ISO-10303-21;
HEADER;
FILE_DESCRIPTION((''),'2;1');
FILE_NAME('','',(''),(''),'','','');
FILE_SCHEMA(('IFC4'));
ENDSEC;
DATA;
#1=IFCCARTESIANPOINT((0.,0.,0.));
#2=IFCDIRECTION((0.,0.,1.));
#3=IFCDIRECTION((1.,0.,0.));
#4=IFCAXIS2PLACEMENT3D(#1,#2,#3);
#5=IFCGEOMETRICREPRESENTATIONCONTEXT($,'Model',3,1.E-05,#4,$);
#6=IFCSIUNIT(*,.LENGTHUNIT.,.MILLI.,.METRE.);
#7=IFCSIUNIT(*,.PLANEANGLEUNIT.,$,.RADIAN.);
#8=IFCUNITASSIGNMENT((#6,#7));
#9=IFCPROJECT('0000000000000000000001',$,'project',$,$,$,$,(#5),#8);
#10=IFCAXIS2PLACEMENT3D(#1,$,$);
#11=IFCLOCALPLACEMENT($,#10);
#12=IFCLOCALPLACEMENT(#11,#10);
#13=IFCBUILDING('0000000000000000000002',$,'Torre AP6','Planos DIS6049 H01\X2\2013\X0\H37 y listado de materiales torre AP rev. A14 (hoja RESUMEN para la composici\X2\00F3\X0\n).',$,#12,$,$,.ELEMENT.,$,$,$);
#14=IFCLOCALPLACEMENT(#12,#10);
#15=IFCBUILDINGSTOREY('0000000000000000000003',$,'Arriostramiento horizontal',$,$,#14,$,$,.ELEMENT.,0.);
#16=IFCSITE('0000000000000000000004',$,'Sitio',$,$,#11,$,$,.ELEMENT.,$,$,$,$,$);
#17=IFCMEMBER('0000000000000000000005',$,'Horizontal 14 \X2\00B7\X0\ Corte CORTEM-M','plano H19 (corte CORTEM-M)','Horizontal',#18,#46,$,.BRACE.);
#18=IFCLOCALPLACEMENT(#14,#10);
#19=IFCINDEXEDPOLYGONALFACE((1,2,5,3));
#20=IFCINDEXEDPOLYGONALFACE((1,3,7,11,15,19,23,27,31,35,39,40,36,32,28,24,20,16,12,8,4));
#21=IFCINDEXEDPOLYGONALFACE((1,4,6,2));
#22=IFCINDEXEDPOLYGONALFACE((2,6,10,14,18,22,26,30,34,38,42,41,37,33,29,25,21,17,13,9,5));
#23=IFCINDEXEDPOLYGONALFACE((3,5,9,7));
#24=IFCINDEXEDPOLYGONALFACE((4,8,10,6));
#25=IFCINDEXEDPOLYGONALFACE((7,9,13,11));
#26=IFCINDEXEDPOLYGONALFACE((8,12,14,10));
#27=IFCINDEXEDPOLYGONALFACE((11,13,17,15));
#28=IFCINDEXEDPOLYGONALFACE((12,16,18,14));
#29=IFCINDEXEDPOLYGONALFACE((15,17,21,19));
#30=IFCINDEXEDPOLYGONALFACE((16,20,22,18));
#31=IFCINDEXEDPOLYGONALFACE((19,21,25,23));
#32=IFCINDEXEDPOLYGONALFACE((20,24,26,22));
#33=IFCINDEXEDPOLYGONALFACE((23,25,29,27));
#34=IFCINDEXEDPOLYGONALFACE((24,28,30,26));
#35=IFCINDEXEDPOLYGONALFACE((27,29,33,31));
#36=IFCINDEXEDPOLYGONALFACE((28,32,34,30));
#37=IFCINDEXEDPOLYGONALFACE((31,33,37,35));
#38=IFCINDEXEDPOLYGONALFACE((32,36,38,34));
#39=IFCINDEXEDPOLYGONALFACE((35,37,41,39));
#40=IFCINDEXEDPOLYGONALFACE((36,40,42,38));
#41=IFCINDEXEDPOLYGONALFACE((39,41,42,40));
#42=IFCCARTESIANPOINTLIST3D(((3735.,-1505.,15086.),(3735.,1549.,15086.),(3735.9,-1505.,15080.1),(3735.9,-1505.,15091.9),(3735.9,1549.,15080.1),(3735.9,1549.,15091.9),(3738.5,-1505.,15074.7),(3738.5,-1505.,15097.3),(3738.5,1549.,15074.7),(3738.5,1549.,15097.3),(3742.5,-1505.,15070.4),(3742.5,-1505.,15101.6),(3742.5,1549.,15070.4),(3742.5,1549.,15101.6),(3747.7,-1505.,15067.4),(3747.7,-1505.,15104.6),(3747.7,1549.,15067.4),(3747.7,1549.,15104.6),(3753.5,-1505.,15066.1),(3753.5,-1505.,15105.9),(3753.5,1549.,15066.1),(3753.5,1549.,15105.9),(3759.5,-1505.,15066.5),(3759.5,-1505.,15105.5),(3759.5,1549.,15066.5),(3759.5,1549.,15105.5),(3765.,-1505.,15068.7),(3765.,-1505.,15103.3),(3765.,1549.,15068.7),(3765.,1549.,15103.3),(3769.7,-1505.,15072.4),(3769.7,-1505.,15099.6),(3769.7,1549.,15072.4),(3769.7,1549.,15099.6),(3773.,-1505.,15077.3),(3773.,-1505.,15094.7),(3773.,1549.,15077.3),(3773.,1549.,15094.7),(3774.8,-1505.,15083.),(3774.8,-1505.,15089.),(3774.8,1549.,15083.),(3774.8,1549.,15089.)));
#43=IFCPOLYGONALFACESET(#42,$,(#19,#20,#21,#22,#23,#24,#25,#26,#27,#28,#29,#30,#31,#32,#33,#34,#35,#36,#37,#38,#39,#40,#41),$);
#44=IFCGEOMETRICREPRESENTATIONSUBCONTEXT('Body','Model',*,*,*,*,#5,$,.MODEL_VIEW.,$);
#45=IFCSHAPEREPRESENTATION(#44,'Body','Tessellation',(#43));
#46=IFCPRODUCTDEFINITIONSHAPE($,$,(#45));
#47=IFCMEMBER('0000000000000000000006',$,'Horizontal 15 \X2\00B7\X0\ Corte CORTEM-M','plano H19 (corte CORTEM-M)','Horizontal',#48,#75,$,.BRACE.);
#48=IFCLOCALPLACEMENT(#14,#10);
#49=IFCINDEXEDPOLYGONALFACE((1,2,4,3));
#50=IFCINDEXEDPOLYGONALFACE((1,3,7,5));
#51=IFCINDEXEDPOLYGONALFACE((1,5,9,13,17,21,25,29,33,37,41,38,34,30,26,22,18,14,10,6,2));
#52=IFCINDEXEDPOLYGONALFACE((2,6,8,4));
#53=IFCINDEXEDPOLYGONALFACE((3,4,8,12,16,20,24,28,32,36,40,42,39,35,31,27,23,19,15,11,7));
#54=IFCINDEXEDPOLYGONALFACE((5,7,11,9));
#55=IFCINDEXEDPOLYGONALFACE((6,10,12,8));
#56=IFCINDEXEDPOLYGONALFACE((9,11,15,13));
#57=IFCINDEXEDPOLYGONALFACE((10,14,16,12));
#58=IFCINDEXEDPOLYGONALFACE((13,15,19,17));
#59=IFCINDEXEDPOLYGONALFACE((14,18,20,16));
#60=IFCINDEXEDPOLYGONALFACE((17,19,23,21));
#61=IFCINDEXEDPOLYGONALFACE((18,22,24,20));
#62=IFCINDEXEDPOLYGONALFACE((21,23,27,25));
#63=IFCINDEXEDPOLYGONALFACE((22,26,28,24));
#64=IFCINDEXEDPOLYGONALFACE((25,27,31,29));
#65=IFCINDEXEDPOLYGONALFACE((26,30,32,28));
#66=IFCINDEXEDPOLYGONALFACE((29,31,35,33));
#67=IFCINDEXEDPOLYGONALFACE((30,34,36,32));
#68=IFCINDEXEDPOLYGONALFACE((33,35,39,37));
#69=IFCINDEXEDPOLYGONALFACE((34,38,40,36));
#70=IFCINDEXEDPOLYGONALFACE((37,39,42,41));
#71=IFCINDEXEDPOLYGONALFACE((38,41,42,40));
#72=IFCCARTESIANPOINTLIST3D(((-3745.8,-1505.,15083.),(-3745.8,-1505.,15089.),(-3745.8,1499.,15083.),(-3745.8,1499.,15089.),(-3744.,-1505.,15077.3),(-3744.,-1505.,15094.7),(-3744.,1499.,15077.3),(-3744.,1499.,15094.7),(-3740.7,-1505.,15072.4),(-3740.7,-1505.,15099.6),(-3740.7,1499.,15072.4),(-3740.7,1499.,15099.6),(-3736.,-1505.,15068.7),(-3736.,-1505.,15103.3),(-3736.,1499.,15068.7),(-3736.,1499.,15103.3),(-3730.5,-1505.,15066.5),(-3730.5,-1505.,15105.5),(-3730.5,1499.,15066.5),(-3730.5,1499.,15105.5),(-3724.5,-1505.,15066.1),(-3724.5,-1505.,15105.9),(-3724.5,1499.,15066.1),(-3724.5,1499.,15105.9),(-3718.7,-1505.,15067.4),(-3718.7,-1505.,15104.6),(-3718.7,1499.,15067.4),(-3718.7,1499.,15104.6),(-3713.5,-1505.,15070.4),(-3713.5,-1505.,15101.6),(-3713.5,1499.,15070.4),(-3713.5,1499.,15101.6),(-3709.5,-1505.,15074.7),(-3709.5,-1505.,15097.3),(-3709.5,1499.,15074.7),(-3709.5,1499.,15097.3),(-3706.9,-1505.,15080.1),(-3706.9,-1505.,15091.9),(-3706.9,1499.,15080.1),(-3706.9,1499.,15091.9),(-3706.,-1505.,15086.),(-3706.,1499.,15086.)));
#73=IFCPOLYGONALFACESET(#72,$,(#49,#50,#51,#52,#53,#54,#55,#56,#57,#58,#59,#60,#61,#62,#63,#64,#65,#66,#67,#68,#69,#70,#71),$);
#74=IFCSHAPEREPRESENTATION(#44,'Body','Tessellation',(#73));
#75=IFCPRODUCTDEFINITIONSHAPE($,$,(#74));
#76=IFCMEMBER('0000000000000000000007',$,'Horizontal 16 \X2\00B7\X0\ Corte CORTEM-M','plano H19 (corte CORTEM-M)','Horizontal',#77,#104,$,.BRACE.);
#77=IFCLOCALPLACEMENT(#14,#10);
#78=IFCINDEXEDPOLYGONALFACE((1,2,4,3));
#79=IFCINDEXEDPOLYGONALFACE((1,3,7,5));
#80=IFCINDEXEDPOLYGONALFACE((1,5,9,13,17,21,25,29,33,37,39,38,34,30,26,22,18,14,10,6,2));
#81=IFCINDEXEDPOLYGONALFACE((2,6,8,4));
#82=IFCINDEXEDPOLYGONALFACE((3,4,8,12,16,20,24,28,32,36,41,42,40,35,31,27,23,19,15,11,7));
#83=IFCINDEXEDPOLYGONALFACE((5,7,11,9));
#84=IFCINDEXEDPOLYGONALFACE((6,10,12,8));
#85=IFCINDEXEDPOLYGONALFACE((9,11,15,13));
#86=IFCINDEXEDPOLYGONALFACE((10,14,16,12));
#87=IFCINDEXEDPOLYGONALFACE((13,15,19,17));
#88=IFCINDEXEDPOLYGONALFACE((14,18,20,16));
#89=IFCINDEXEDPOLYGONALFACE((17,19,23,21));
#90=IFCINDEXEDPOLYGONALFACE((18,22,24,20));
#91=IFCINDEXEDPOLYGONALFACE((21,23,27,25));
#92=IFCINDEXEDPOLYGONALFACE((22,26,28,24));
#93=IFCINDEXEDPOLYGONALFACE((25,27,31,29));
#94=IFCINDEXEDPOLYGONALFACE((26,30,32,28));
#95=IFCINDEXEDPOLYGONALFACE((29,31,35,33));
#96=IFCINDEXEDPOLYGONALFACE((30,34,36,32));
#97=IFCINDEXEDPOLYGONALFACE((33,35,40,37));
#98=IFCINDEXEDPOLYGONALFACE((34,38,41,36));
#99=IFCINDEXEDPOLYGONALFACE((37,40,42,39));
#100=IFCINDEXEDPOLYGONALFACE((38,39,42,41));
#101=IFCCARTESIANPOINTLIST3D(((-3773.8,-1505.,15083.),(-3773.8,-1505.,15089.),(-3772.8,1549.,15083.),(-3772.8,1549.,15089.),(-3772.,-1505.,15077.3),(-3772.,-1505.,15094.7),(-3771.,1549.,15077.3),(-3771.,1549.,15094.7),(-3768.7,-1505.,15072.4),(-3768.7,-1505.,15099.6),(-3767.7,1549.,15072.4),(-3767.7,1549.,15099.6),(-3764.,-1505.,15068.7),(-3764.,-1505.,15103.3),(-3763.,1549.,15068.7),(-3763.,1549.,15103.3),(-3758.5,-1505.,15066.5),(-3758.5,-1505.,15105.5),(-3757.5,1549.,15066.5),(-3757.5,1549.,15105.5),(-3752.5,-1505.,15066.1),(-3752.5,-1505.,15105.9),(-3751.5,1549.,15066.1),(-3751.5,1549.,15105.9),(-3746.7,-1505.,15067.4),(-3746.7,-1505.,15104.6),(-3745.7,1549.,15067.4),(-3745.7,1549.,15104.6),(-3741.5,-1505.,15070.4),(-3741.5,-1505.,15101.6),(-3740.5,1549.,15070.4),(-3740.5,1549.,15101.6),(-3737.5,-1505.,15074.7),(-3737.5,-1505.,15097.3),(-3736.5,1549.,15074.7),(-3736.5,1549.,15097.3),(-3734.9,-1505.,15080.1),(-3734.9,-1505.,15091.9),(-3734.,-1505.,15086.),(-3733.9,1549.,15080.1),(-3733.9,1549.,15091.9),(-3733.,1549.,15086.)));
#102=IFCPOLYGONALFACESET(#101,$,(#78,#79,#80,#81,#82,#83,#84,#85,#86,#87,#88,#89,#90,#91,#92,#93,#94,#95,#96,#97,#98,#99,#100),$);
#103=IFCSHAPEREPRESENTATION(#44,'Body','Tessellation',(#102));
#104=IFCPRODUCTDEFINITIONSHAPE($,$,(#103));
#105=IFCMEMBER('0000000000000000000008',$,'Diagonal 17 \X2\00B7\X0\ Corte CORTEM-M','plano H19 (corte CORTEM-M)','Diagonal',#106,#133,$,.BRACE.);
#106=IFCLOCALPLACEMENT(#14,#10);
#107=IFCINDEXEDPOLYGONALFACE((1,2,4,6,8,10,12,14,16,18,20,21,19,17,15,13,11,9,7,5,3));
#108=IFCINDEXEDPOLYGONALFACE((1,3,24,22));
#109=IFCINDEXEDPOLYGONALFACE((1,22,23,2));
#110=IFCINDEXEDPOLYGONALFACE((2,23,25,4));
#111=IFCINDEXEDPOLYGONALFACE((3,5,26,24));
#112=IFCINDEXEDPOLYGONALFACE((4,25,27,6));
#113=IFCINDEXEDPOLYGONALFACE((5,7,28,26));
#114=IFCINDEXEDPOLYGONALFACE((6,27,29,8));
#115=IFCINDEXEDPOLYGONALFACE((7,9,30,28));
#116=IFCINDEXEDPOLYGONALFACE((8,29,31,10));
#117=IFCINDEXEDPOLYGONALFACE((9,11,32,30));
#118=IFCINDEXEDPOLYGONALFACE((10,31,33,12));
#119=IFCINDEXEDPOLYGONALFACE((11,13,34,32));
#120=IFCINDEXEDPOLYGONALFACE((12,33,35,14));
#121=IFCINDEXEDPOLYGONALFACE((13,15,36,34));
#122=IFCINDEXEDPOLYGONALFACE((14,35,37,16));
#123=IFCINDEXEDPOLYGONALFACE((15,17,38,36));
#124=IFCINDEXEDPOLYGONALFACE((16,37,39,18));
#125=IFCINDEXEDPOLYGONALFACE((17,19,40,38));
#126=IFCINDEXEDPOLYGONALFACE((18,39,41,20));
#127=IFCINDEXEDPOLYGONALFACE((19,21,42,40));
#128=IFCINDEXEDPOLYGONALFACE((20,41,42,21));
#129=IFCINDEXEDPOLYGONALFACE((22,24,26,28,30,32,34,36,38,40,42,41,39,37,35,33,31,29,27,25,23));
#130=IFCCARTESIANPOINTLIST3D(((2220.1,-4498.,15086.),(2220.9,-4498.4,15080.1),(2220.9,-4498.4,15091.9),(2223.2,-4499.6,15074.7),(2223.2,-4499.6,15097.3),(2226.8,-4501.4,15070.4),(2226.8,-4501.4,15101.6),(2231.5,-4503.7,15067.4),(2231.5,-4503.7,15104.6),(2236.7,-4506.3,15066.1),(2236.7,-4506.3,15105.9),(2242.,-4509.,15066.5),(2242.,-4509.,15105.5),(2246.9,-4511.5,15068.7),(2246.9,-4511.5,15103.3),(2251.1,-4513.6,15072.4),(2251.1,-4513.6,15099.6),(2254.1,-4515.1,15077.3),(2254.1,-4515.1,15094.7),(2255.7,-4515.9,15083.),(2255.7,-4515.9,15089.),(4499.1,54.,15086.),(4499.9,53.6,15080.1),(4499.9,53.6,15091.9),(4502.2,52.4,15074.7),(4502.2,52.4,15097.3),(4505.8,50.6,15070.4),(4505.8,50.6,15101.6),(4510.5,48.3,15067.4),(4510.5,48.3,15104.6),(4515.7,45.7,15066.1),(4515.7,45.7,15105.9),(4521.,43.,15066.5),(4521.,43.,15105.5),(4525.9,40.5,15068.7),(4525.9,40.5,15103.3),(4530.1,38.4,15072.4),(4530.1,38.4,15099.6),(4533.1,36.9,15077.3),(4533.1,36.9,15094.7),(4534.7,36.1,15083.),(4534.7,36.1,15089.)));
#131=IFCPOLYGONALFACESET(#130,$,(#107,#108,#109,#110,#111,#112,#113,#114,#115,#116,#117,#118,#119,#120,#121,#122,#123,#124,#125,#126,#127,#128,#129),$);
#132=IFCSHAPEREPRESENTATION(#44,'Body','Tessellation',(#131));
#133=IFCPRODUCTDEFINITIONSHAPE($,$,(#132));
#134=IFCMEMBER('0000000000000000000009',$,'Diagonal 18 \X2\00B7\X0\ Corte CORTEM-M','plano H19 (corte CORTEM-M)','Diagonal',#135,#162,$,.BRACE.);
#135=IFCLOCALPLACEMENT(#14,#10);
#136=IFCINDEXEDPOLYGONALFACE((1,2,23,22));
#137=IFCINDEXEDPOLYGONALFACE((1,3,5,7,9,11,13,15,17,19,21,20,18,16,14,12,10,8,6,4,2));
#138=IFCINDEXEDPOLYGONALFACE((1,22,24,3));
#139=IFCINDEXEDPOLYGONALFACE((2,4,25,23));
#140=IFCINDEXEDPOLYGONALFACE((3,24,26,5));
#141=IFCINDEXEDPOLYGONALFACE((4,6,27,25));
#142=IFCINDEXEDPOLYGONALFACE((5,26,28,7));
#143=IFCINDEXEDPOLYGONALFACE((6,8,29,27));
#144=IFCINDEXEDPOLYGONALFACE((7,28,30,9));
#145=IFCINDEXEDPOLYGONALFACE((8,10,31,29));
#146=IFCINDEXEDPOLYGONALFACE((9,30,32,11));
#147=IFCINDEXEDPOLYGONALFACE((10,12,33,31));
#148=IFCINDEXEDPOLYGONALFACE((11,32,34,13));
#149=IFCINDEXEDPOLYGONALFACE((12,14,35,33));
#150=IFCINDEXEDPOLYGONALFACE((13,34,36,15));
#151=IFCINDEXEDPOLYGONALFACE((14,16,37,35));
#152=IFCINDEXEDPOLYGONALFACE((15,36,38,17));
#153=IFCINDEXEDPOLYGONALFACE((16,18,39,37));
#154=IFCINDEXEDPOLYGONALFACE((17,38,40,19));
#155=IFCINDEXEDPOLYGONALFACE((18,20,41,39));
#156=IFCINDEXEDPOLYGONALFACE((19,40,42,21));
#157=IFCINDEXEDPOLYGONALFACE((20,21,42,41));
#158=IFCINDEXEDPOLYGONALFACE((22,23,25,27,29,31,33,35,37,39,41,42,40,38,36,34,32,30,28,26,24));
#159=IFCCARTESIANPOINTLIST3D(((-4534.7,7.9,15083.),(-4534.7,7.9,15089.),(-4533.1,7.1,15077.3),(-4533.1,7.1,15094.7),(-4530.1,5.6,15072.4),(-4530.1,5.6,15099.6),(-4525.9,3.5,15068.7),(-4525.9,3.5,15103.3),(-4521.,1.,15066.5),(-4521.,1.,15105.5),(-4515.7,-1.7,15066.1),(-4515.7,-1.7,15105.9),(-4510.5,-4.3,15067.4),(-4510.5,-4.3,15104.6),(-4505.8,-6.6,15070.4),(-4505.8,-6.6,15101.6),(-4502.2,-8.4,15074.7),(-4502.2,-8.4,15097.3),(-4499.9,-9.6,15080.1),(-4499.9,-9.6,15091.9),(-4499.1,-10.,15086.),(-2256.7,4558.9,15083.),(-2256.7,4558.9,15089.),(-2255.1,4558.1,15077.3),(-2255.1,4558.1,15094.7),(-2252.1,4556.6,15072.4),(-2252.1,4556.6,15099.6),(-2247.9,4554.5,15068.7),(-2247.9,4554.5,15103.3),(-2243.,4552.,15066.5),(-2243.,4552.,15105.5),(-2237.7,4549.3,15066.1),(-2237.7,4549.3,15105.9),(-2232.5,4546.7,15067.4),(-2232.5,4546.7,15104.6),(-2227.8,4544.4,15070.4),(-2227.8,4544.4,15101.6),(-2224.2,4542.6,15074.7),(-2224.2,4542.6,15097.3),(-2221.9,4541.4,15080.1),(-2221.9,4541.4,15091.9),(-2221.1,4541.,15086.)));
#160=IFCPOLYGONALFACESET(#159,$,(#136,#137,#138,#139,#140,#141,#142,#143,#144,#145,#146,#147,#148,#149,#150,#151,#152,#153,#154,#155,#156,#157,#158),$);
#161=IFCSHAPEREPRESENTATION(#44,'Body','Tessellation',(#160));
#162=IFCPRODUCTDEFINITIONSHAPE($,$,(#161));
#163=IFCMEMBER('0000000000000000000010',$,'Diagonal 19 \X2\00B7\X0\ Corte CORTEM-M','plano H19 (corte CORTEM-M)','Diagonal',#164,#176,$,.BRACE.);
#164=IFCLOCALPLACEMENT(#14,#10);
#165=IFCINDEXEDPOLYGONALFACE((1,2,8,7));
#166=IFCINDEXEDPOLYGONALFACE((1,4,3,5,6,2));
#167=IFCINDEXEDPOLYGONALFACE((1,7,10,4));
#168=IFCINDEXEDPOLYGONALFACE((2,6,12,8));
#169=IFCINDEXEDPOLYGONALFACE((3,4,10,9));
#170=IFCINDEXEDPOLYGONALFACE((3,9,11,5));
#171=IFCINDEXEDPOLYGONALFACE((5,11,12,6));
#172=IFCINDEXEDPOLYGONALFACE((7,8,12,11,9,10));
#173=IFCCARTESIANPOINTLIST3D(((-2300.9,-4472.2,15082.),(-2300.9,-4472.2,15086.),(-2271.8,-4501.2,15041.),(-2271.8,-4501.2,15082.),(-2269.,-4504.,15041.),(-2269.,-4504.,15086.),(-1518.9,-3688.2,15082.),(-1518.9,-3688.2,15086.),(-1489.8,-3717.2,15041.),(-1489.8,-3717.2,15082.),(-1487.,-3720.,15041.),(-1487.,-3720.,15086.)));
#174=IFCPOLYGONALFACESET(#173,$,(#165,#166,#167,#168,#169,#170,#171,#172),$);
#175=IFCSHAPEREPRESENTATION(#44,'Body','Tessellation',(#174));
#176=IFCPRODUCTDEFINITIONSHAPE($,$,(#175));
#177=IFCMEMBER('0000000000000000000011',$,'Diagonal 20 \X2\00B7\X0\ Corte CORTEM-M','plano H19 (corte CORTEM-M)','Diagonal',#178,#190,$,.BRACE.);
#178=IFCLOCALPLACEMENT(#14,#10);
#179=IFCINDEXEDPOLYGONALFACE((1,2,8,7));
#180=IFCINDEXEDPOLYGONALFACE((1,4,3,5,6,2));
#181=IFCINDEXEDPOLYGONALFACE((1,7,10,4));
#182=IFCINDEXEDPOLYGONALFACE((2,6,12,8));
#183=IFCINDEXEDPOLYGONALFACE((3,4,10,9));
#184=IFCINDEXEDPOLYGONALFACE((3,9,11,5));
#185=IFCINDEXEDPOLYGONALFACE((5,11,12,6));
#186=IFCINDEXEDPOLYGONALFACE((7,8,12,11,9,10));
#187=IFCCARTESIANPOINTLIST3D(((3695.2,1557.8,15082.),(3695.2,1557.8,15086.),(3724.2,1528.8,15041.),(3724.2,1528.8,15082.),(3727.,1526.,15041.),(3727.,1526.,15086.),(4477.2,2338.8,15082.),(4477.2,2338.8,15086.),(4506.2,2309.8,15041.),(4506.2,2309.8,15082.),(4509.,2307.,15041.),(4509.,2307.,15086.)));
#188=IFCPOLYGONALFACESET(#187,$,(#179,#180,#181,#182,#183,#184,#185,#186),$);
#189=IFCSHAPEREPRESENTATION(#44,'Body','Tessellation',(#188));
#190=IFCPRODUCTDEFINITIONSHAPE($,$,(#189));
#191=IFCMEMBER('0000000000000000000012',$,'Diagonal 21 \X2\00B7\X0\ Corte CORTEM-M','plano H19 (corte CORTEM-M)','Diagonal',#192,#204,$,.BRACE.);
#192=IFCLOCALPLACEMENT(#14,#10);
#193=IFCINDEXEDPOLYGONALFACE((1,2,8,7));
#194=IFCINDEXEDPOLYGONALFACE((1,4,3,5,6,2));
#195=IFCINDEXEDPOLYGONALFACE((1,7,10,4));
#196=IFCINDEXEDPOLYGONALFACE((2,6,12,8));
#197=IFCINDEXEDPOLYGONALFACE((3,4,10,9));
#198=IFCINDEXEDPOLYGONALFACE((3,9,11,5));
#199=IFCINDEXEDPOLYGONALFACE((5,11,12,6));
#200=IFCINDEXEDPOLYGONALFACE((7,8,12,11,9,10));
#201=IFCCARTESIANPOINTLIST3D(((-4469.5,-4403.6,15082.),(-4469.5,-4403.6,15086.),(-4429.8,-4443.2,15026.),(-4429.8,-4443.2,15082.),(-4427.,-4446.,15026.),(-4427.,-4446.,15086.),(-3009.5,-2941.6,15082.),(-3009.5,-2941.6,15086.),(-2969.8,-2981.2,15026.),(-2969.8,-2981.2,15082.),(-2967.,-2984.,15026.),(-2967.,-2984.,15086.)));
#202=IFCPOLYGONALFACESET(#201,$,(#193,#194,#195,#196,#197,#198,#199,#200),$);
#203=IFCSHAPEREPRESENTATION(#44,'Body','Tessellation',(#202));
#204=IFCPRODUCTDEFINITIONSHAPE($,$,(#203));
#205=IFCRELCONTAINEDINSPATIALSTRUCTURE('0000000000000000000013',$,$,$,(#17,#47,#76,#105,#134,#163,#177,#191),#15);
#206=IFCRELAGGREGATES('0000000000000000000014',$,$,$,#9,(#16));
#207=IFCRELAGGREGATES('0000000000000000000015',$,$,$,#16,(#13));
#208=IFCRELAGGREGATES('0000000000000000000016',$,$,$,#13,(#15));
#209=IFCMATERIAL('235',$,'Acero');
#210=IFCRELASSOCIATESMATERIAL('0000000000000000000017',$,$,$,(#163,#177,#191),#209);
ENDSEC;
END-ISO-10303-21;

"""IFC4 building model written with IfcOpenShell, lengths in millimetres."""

from ifc_helpers import new_model, si_unit, frame, frame_2d, origin, origin_with_axes, place, context, subcontext, project, spatial, circle, l_section, extrude, material, element, save


model = new_model("IFC4")

# Units and contexts
model_context = context("Model", 3, precision=1e-05, world=origin_with_axes())
body_context = subcontext(model_context, "Body", "Model", "MODEL_VIEW")
ifc_project = project(units=[si_unit("LENGTHUNIT", "METRE", prefix="MILLI"), si_unit("PLANEANGLEUNIT", "RADIAN")], contexts=[model_context])

# Site, building, storey
site_placement = place(None, origin())
site = spatial("IfcSite", under=ifc_project, at=site_placement, Name="Sitio", CompositionType="ELEMENT")
building_placement = place(site_placement, origin())
building = spatial("IfcBuilding", under=site, at=building_placement, Name="Torre AP6", Description="Planos DIS6049 H01–H37 y listado de materiales torre AP rev. A14 (hoja RESUMEN para la composición).", CompositionType="ELEMENT")
storey_placement = place(building_placement, origin())
storey = spatial("IfcBuildingStorey", under=building, at=storey_placement, Name="Arriostramiento horizontal", CompositionType="ELEMENT", Elevation=0.0)

# Members
ifc_material = material(Name="235", Category="Acero")
member_1_placement = place(storey_placement, frame((3755.0, 1549.0, 15086.0), z_axis=(0.0, -1.0, 0.0), x_axis=(-1.0, 0.0, 0.0)))
element("IfcMember", 1, at=member_1_placement, inside=storey, Name="Horizontal 14 · Corte CORTEM-M", Description="plano H19 (corte CORTEM-M)", ObjectType="Horizontal", PredefinedType="BRACE", context=body_context, shape_type="SweptSolid", body=[
    extrude(circle(Radius=20.0), None, (0.0, 0.0, 1.0), 3054.0),
])
member_2_placement = place(storey_placement, frame((-3726.0, 1499.0, 15086.0), z_axis=(0.0, -1.0, 0.0), x_axis=(1.0, 0.0, 0.0)))
element("IfcMember", 2, at=member_2_placement, inside=storey, Name="Horizontal 15 · Corte CORTEM-M", Description="plano H19 (corte CORTEM-M)", ObjectType="Horizontal", PredefinedType="BRACE", context=body_context, shape_type="SweptSolid", body=[
    extrude(circle(Radius=20.0), None, (0.0, 0.0, 1.0), 3004.0),
])
member_3_placement = place(storey_placement, frame((-3753.0, 1549.0, 15086.0), z_axis=(-0.000327, -1.0, 0.0), x_axis=(1.0, -0.000327, 0.0)))
element("IfcMember", 3, at=member_3_placement, inside=storey, Name="Horizontal 16 · Corte CORTEM-M", Description="plano H19 (corte CORTEM-M)", ObjectType="Horizontal", PredefinedType="BRACE", context=body_context, shape_type="SweptSolid", body=[
    extrude(circle(Radius=20.0), None, (0.0, 0.0, 1.0), 3054.0),
])
member_4_placement = place(storey_placement, frame((4517.0, 45.0, 15086.0), z_axis=(-0.447685, -0.894191, 0.0), x_axis=(-0.894191, 0.447685, 0.0)))
element("IfcMember", 4, at=member_4_placement, inside=storey, Name="Diagonal 17 · Corte CORTEM-M", Description="plano H19 (corte CORTEM-M)", ObjectType="Diagonal", PredefinedType="BRACE", context=body_context, shape_type="SweptSolid", body=[
    extrude(circle(Radius=20.0), None, (0.0, 0.0, 1.0), 5090.6),
])
member_5_placement = place(storey_placement, frame((-2239.0, 4550.0, 15086.0), z_axis=(-0.447607, -0.894231, 0.0), x_axis=(0.894231, -0.447607, 0.0)))
element("IfcMember", 5, at=member_5_placement, inside=storey, Name="Diagonal 18 · Corte CORTEM-M", Description="plano H19 (corte CORTEM-M)", ObjectType="Diagonal", PredefinedType="BRACE", context=body_context, shape_type="SweptSolid", body=[
    extrude(circle(Radius=20.0), None, (0.0, 0.0, 1.0), 5089.3),
])
member_6_placement = place(storey_placement, frame((-1487.0, -3720.0, 15086.0), z_axis=(-0.706203, -0.708009, 0.0), x_axis=(-0.708009, 0.706203, 0.0)))
element("IfcMember", 6, at=member_6_placement, inside=storey, material=ifc_material, Name="Diagonal 19 · Corte CORTEM-M", Description="plano H19 (corte CORTEM-M)", ObjectType="Diagonal", PredefinedType="BRACE", context=body_context, shape_type="SweptSolid", body=[
    extrude(l_section(Depth=45.0, Width=45.0, Thickness=4.0, at=frame_2d((22.5, 22.5))), None, (0.0, 0.0, 1.0), 1107.3),
])
member_7_placement = place(storey_placement, frame((4509.0, 2307.0, 15086.0), z_axis=(-0.707559, -0.706654, 0.0), x_axis=(-0.706654, 0.707559, 0.0)))
element("IfcMember", 7, at=member_7_placement, inside=storey, material=ifc_material, Name="Diagonal 20 · Corte CORTEM-M", Description="plano H19 (corte CORTEM-M)", ObjectType="Diagonal", PredefinedType="BRACE", context=body_context, shape_type="SweptSolid", body=[
    extrude(l_section(Depth=45.0, Width=45.0, Thickness=4.0, at=frame_2d((22.5, 22.5))), None, (0.0, 0.0, 1.0), 1105.2),
])
for number, where, z_axis, x_axis, name in (
    (8, (-2967.0, -2984.0, 15086.0), (-0.706623, -0.707591, 0.0), (-0.707591, 0.706623, 0.0), "Diagonal 21 · Corte CORTEM-M"),
):
    element("IfcMember", number, at=place(storey_placement, frame(where, z_axis=z_axis, x_axis=x_axis)), inside=storey, material=ifc_material, Name=name, Description="plano H19 (corte CORTEM-M)", ObjectType="Diagonal", PredefinedType="BRACE", context=body_context, shape_type="SweptSolid", body=[
        extrude(l_section(Depth=60.0, Width=60.0, Thickness=4.0, at=frame_2d((30.0, 30.0))), None, (0.0, 0.0, 1.0), 2066.2),
    ])

save(model, "model.ifc")
